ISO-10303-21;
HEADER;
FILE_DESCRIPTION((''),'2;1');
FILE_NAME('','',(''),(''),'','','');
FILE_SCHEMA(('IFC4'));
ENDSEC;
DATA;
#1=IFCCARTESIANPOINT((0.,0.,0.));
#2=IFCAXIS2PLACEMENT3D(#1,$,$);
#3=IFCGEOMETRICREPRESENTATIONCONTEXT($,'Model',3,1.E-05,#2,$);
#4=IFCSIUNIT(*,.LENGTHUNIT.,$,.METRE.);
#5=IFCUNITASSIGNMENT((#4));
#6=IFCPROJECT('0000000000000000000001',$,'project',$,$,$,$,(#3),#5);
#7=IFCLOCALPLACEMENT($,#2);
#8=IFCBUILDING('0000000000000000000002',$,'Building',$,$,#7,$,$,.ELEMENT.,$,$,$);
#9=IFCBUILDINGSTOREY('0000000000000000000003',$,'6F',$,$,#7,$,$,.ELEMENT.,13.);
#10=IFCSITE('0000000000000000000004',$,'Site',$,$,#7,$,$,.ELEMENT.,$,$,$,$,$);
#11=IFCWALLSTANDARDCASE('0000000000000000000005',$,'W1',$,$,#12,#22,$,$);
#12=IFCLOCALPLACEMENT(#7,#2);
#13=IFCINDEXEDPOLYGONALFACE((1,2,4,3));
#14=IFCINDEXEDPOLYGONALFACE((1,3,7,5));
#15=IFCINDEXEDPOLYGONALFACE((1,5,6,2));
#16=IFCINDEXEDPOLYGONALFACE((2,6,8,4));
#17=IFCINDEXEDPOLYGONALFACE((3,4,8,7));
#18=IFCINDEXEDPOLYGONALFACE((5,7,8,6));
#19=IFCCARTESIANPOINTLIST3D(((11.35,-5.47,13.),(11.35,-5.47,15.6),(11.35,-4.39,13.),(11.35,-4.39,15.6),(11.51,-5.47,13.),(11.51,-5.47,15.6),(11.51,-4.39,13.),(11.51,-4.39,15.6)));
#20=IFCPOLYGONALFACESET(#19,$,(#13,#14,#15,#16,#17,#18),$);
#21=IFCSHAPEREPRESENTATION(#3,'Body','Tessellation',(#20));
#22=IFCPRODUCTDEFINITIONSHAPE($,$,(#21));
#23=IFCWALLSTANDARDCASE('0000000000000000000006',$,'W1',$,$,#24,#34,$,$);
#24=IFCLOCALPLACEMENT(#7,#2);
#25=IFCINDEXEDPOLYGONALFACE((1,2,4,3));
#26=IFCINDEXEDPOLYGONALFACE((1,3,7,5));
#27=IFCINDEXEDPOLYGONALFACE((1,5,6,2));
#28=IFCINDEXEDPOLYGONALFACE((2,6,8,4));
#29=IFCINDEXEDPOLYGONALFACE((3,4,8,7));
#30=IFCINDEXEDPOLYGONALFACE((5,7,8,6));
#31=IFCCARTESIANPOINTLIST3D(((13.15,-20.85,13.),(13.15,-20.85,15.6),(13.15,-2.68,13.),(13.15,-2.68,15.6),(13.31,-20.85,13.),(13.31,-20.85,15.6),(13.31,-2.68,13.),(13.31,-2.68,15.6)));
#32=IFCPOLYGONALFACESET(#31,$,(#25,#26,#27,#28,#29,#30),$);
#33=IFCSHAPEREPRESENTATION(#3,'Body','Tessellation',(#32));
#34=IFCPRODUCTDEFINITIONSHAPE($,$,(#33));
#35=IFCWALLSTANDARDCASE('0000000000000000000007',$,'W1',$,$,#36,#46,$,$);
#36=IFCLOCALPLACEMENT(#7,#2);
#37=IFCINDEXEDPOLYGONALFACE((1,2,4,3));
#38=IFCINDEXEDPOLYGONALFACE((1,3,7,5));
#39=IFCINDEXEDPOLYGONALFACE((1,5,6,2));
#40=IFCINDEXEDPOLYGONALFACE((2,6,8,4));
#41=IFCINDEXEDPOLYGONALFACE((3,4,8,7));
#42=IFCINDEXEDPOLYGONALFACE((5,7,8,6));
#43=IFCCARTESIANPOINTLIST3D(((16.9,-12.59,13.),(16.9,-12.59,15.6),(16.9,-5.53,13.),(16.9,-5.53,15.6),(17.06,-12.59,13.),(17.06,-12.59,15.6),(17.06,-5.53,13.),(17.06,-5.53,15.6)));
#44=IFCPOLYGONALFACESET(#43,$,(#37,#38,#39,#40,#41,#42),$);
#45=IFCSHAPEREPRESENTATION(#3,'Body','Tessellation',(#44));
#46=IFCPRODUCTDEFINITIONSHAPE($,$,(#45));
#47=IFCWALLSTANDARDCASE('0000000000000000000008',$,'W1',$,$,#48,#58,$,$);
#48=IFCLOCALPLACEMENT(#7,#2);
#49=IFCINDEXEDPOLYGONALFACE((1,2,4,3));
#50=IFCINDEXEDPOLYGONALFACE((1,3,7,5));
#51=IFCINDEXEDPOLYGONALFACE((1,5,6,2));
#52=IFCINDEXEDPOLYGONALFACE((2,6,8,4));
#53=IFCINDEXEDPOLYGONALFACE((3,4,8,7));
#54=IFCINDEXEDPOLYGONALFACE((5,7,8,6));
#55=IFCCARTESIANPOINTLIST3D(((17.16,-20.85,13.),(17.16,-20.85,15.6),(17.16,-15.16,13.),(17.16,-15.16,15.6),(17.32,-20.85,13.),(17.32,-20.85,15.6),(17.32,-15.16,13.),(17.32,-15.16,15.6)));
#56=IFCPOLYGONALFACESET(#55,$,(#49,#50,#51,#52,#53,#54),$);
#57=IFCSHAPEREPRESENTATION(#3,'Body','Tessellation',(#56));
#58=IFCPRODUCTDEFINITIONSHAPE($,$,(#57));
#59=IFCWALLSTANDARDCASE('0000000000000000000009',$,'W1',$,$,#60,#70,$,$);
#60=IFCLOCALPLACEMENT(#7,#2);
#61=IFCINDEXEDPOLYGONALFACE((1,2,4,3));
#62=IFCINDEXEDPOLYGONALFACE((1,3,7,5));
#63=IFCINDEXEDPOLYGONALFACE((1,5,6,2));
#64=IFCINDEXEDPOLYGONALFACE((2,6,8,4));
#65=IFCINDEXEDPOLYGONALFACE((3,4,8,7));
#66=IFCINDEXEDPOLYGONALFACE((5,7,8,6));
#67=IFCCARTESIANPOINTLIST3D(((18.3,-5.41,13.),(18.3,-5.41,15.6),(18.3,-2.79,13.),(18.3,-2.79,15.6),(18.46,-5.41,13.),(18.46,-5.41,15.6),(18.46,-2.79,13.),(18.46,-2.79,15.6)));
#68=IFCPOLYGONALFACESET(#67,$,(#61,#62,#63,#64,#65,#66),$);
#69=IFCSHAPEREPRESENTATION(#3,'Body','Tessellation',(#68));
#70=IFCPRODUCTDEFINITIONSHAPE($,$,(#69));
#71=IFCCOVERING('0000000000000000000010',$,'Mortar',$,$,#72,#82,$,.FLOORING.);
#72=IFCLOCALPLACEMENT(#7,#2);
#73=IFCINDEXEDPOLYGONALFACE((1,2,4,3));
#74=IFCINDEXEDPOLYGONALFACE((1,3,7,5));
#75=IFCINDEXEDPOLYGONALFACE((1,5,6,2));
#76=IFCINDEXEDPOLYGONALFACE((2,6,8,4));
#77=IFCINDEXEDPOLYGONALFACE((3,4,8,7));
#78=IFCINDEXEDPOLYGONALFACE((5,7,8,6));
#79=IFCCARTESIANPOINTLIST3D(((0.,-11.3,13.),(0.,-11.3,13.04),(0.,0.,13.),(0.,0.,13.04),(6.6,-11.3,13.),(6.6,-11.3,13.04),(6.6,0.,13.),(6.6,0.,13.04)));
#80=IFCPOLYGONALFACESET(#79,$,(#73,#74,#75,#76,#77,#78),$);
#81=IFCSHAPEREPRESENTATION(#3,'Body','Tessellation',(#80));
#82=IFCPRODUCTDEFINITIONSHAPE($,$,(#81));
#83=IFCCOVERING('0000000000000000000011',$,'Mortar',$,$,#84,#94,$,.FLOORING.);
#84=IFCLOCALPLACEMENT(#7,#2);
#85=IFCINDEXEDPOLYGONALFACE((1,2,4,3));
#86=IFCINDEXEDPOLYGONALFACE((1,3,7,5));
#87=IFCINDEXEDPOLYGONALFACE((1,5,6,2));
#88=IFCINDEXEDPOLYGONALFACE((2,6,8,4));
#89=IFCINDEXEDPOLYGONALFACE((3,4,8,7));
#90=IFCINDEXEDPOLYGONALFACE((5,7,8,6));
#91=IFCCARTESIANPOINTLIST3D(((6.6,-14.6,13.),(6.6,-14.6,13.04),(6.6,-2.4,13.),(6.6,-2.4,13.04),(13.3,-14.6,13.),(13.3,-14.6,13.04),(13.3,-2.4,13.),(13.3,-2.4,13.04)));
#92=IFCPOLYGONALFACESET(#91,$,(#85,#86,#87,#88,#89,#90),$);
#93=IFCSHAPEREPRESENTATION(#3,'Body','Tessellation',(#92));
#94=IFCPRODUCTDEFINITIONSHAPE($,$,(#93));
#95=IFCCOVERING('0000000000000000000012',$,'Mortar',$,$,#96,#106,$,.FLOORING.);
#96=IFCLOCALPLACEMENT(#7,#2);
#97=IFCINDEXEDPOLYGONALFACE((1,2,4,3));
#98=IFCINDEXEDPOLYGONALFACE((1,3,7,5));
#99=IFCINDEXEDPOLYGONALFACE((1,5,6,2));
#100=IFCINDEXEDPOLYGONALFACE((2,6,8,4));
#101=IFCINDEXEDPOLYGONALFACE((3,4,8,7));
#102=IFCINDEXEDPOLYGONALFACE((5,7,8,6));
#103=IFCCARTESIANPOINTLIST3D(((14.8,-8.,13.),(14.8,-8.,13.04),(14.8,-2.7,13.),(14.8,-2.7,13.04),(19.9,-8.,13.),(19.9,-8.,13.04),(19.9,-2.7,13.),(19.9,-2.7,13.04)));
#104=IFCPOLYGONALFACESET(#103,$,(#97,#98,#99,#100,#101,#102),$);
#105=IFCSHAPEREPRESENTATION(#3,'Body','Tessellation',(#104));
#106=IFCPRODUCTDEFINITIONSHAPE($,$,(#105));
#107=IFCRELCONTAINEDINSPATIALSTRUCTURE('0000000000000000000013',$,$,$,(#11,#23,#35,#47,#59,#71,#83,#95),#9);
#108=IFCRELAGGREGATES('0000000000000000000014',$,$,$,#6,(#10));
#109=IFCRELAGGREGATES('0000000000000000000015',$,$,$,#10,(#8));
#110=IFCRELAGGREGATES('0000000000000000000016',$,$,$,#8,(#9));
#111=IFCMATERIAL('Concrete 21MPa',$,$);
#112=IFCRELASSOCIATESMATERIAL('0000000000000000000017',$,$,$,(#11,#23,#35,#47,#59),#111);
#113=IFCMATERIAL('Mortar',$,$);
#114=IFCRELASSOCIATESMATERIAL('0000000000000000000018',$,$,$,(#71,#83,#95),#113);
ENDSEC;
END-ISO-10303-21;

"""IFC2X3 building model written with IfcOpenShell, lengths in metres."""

from ifc_helpers import new_model, si_unit, frame, origin, origin_2d, place, context, project, spatial, rectangle, extrude, material, element, save


model = new_model("IFC2X3")

# Units and contexts
model_context = context("Model", 3, precision=1e-05, world=origin())
ifc_project = project(units=[si_unit("LENGTHUNIT", "METRE")], contexts=[model_context])

# Site, building, storey
placement = place(None, origin())
site = spatial("IfcSite", under=ifc_project, at=placement, Name="Site", CompositionType="ELEMENT")
building = spatial("IfcBuilding", under=site, at=placement, Name="Building", CompositionType="ELEMENT")
storey = spatial("IfcBuildingStorey", under=building, at=placement, Name="6F", CompositionType="ELEMENT", Elevation=13.0)

# Shared definitions
ifc_material_1 = material(Name="Concrete 21MPa")

# Walls
wall_1_placement = place(None, frame((11.43, -4.93, 13.0)))
element("IfcWallStandardCase", 1, at=wall_1_placement, inside=storey, material=ifc_material_1, Name="W1", context=model_context, shape_type="SweptSolid", body=[
    extrude(rectangle(XDim=0.16, YDim=1.08, at=origin_2d()), origin(), (0.0, 0.0, 1.0), 2.6),
])
wall_2_placement = place(None, frame((13.23, -11.765, 13.0)))
element("IfcWallStandardCase", 2, at=wall_2_placement, inside=storey, material=ifc_material_1, Name="W1", context=model_context, shape_type="SweptSolid", body=[
    extrude(rectangle(XDim=0.16, YDim=18.17, at=origin_2d()), origin(), (0.0, 0.0, 1.0), 2.6),
])
wall_3_placement = place(None, frame((16.98, -9.06, 13.0)))
element("IfcWallStandardCase", 3, at=wall_3_placement, inside=storey, material=ifc_material_1, Name="W1", context=model_context, shape_type="SweptSolid", body=[
    extrude(rectangle(XDim=0.16, YDim=7.06, at=origin_2d()), origin(), (0.0, 0.0, 1.0), 2.6),
])
wall_4_placement = place(None, frame((17.24, -18.005, 13.0)))
element("IfcWallStandardCase", 4, at=wall_4_placement, inside=storey, material=ifc_material_1, Name="W1", context=model_context, shape_type="SweptSolid", body=[
    extrude(rectangle(XDim=0.16, YDim=5.69, at=origin_2d()), origin(), (0.0, 0.0, 1.0), 2.6),
])
wall_5_placement = place(None, frame((18.38, -4.1, 13.0)))
element("IfcWallStandardCase", 5, at=wall_5_placement, inside=storey, material=ifc_material_1, Name="W1", context=model_context, shape_type="SweptSolid", body=[
    extrude(rectangle(XDim=0.16, YDim=2.62, at=origin_2d()), origin(), (0.0, 0.0, 1.0), 2.6),
])

# Coverings
ifc_material_2 = material(Name="Mortar")
covering_1_placement = place(None, frame((3.3, -5.65, 13.0)))
element("IfcCovering", 6, at=covering_1_placement, inside=storey, material=ifc_material_2, Name="Mortar", PredefinedType="FLOORING", context=model_context, shape_type="SweptSolid", body=[
    extrude(rectangle(XDim=6.6, YDim=11.3, at=origin_2d()), origin(), (0.0, 0.0, 1.0), 0.04),
])
covering_2_placement = place(None, frame((9.95, -8.5, 13.0)))
element("IfcCovering", 7, at=covering_2_placement, inside=storey, material=ifc_material_2, Name="Mortar", PredefinedType="FLOORING", context=model_context, shape_type="SweptSolid", body=[
    extrude(rectangle(XDim=6.7, YDim=12.2, at=origin_2d()), origin(), (0.0, 0.0, 1.0), 0.04),
])
covering_3_placement = place(None, frame((17.35, -5.35, 13.0)))
element("IfcCovering", 8, at=covering_3_placement, inside=storey, material=ifc_material_2, Name="Mortar", PredefinedType="FLOORING", context=model_context, shape_type="SweptSolid", body=[
    extrude(rectangle(XDim=5.1, YDim=5.3, at=origin_2d()), origin(), (0.0, 0.0, 1.0), 0.04),
])

save(model, "model.ifc")
